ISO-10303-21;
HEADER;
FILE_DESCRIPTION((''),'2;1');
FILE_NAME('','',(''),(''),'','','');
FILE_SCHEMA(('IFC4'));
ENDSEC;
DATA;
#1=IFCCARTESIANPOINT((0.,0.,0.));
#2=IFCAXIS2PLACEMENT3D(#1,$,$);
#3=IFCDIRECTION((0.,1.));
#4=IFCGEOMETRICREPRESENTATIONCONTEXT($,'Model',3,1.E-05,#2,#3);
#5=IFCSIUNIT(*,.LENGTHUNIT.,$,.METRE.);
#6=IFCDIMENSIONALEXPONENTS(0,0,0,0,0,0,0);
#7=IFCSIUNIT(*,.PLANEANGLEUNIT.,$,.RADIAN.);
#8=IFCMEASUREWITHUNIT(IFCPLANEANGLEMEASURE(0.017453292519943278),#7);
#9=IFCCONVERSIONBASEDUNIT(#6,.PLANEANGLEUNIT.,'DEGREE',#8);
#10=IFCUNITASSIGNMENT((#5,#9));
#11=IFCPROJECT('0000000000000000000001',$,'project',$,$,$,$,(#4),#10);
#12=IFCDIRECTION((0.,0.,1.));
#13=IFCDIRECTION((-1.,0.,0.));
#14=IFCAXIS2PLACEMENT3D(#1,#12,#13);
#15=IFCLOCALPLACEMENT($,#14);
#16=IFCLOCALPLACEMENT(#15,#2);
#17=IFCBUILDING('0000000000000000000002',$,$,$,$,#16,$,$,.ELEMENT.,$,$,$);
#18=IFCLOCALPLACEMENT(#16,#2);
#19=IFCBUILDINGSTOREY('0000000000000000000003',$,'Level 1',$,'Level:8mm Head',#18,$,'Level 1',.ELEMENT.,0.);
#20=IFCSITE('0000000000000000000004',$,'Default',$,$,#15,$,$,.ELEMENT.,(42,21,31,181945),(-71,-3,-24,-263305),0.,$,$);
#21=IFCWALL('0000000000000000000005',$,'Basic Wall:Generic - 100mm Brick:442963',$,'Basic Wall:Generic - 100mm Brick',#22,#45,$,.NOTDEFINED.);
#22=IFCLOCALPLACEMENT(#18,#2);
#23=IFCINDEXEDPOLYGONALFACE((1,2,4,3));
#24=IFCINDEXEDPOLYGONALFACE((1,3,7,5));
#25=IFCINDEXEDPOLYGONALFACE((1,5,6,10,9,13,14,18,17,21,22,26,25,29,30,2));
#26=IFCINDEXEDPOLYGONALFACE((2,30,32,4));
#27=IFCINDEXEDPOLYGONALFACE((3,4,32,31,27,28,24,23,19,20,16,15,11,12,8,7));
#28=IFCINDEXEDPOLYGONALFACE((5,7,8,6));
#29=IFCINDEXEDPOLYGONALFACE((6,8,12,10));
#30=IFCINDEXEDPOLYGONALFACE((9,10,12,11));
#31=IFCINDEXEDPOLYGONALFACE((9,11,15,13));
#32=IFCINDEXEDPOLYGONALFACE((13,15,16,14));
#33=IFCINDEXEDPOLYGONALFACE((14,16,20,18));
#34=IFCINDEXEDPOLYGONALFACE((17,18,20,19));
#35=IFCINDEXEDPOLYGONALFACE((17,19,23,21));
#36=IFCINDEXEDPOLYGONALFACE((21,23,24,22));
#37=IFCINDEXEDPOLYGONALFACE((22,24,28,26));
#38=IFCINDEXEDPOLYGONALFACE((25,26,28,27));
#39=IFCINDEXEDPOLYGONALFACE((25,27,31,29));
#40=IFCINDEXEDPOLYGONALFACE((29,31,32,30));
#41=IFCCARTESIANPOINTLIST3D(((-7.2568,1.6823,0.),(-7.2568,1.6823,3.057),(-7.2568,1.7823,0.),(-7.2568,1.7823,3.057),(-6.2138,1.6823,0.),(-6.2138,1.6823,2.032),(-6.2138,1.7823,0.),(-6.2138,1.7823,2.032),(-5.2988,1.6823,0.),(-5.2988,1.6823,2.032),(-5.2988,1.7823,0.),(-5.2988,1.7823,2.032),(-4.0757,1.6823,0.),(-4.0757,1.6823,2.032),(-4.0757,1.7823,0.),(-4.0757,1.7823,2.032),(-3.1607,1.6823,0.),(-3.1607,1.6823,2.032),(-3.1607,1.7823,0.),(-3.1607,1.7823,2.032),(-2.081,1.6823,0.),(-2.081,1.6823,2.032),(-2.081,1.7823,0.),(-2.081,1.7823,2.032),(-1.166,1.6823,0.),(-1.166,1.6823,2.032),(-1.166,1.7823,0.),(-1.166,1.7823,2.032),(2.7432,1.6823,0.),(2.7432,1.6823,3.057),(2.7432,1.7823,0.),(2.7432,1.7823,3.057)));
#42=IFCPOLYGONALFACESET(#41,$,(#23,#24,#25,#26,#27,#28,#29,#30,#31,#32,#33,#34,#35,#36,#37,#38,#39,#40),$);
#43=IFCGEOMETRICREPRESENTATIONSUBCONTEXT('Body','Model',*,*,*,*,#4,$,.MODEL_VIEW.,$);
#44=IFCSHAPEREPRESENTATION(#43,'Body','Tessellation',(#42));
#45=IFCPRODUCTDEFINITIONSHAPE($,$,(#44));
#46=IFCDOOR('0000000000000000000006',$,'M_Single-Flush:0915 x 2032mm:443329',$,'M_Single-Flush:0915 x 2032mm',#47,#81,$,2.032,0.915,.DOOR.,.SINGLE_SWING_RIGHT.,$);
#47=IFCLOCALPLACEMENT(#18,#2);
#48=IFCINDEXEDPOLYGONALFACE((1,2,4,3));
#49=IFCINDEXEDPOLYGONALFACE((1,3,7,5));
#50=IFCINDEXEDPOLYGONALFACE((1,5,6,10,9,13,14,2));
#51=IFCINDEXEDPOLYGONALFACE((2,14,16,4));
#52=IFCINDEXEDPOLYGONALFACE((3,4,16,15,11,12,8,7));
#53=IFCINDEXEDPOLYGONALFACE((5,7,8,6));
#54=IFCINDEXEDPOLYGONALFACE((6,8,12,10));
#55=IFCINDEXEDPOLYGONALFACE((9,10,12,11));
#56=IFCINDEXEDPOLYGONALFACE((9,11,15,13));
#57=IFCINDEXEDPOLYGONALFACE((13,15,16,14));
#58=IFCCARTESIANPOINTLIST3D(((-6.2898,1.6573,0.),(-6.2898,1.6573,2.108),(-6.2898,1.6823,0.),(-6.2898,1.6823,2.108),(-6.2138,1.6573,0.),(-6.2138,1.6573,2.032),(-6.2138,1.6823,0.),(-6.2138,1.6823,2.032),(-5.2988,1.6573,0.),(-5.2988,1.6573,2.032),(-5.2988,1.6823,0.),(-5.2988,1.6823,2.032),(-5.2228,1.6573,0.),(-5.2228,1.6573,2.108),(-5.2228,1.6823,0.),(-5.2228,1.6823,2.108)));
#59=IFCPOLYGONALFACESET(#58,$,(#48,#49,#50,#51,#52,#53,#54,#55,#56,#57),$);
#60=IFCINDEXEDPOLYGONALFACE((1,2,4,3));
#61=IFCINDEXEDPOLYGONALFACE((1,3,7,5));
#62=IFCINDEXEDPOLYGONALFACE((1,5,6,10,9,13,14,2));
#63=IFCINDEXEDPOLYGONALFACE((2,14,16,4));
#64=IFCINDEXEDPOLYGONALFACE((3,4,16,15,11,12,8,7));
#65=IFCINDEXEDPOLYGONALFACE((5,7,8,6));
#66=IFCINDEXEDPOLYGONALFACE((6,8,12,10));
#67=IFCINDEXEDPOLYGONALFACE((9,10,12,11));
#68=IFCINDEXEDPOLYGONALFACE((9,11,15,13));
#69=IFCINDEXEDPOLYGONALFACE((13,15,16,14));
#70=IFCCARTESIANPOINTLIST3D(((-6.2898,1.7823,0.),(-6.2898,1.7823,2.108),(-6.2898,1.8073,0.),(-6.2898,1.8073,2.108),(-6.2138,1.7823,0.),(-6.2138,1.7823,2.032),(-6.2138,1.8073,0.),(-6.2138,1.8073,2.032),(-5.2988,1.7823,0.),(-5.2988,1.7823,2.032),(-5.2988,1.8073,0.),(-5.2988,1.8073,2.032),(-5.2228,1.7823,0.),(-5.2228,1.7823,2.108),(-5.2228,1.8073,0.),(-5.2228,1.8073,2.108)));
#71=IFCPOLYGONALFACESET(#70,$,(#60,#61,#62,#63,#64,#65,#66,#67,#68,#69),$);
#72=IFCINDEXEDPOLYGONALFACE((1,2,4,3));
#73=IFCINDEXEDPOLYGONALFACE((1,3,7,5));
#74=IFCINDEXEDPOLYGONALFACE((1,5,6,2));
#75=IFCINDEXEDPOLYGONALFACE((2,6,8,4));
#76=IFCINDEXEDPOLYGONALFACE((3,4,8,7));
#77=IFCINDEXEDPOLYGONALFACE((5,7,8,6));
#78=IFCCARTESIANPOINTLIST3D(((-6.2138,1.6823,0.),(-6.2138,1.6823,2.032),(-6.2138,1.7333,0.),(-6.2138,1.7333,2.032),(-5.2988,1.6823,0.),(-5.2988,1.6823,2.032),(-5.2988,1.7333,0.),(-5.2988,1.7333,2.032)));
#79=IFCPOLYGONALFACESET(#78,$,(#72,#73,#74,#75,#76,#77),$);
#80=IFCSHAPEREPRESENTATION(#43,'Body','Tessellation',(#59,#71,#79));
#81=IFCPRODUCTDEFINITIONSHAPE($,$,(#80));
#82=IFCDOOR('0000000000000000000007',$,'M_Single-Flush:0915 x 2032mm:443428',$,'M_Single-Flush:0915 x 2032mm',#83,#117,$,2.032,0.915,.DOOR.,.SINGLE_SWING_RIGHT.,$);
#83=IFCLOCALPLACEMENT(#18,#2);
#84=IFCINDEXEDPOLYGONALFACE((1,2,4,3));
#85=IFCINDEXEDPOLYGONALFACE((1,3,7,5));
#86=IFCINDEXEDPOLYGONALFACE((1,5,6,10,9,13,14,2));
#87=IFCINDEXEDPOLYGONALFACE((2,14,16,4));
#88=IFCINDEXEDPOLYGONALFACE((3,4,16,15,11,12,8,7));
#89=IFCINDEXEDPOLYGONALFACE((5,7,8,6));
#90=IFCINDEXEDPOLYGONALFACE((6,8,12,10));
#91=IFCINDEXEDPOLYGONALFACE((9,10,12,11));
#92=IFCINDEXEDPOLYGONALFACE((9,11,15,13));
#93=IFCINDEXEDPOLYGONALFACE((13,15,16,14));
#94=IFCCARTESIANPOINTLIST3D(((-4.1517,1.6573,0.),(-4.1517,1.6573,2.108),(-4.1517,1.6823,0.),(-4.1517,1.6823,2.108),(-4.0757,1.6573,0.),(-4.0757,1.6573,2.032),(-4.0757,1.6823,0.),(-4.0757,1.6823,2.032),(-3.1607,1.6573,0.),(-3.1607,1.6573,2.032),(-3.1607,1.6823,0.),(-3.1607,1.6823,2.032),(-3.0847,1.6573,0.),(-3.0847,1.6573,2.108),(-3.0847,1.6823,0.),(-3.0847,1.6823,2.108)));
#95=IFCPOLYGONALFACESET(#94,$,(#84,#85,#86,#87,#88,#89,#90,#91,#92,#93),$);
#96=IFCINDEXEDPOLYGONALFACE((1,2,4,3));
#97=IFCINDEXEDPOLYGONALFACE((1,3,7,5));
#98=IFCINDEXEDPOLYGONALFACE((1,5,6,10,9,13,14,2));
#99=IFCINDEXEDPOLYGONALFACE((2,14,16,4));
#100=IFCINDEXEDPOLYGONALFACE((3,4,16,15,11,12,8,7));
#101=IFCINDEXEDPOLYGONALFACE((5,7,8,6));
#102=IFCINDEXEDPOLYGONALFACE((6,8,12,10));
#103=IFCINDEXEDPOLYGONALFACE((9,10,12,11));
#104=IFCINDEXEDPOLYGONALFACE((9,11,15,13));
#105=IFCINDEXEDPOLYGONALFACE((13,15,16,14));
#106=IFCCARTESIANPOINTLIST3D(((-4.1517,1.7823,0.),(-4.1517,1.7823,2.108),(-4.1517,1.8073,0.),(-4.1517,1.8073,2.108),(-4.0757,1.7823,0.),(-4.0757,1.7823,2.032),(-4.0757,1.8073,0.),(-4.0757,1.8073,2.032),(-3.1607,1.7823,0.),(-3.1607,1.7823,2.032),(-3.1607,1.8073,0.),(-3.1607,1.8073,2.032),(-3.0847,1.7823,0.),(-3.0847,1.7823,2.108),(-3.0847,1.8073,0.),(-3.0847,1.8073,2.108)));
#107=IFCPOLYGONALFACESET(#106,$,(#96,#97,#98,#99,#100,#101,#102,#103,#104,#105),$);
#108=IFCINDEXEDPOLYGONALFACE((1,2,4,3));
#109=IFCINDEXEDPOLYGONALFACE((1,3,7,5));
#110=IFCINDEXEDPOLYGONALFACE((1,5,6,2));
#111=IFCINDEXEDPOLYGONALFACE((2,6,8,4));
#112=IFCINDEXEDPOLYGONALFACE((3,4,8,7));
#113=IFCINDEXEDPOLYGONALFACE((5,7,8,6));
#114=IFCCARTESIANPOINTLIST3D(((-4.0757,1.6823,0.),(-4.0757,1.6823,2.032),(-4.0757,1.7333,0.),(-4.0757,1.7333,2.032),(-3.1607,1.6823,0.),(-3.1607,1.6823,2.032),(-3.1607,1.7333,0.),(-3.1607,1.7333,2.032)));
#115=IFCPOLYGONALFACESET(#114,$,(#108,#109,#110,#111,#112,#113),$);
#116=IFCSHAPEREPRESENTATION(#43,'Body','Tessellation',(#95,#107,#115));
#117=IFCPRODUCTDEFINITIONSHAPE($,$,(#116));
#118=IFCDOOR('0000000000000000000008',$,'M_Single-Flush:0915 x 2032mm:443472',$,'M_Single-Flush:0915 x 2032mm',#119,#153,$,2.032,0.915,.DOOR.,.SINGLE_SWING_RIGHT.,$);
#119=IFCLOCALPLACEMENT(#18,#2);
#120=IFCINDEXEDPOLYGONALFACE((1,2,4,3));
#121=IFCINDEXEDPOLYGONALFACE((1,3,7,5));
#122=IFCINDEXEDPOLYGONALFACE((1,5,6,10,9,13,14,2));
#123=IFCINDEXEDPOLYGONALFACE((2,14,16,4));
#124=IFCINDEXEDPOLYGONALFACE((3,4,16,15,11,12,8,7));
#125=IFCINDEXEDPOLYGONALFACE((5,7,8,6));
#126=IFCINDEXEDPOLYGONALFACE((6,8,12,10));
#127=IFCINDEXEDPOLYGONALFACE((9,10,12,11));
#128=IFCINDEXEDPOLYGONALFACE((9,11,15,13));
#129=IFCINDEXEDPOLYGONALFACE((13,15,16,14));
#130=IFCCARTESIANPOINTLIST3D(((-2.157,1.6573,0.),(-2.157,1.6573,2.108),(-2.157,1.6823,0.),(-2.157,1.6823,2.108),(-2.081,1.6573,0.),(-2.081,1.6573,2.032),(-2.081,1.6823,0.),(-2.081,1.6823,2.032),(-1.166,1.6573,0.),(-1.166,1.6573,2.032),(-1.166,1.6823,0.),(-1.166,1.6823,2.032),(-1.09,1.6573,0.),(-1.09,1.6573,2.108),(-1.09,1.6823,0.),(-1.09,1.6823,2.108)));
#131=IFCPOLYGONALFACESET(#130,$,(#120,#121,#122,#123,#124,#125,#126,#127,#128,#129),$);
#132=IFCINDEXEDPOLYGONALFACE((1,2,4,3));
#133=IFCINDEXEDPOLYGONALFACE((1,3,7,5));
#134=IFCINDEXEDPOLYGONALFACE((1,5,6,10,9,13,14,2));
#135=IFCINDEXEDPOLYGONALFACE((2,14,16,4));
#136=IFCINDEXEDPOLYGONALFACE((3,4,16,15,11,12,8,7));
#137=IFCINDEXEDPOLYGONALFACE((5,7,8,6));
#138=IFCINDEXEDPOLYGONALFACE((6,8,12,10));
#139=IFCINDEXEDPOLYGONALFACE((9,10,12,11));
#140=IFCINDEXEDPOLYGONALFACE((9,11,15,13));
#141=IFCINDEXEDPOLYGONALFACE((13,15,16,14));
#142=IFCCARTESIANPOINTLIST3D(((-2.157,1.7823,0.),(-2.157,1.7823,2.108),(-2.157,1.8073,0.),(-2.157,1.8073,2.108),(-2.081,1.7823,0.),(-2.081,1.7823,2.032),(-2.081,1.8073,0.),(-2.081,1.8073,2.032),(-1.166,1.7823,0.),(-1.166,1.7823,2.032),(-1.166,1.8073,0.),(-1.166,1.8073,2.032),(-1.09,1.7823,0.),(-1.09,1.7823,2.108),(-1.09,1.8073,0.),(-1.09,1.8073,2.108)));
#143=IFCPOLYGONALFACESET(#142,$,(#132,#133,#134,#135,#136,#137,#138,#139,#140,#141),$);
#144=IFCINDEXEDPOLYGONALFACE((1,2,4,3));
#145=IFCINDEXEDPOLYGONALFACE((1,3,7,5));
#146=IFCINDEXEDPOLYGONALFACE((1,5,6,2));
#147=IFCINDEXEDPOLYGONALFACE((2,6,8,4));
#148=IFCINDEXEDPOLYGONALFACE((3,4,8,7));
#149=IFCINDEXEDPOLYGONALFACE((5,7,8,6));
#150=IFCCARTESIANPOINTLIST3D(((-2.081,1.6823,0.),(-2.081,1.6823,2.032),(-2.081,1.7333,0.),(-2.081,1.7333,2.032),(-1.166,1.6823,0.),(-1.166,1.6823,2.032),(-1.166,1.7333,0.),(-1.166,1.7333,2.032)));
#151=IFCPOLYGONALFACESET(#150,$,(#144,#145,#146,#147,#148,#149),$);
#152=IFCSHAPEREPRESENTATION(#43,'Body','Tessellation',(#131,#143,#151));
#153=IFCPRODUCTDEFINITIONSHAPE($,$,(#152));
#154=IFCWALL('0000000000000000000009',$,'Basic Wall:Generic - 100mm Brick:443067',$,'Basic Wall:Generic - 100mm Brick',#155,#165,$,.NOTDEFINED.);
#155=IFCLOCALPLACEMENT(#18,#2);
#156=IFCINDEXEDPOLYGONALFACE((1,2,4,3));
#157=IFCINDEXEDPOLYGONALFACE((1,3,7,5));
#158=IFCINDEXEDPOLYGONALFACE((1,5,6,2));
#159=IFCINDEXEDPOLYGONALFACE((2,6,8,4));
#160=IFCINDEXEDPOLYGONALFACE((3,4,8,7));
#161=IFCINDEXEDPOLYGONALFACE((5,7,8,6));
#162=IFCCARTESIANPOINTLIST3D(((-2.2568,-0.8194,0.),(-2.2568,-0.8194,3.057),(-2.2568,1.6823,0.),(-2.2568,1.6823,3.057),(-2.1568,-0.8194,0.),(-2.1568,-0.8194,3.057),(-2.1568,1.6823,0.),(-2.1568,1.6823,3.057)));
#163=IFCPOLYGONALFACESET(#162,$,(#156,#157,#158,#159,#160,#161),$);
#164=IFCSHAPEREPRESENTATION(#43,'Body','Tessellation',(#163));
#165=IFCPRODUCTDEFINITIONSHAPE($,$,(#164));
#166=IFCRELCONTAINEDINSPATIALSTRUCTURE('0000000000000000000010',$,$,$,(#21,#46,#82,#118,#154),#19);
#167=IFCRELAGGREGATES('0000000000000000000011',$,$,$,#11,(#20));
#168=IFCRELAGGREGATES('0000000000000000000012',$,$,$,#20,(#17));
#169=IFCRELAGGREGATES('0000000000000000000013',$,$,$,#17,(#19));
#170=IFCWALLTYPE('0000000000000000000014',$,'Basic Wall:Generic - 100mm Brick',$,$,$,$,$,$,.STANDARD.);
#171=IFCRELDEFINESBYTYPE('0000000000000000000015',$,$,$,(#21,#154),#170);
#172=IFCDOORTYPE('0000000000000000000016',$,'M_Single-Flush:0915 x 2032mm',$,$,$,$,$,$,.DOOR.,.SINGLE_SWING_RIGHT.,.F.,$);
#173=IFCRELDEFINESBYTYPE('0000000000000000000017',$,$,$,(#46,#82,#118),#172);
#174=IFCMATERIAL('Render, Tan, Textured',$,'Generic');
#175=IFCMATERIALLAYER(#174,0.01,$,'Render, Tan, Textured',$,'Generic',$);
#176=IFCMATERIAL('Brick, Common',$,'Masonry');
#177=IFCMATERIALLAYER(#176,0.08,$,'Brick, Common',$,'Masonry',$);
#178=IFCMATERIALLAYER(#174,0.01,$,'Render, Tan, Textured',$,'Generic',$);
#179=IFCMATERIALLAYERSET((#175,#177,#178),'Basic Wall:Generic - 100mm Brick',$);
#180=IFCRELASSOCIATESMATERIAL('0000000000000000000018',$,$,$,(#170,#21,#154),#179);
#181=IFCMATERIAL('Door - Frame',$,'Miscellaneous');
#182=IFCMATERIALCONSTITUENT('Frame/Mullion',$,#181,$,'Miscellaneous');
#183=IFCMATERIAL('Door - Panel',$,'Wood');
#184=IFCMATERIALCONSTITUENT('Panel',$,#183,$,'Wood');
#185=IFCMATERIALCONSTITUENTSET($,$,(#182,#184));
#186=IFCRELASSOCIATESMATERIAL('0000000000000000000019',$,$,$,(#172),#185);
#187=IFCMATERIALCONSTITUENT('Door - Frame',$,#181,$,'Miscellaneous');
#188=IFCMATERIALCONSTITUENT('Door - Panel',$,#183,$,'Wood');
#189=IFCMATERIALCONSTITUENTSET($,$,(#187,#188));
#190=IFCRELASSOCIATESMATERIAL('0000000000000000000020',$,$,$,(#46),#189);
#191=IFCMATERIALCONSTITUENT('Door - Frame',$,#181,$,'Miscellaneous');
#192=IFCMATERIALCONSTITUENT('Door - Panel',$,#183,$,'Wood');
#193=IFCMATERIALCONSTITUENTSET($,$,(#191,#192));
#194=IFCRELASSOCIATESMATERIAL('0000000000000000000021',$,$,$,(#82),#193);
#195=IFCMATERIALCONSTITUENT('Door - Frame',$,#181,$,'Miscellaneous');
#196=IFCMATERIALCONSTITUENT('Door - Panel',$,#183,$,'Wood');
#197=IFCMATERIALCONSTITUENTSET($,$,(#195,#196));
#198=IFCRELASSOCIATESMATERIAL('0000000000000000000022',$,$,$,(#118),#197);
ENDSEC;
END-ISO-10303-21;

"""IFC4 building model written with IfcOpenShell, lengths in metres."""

from ifc_helpers import new_model, entity, si_unit, converted_unit, direction, frame, frame_2d, origin, place, context, subcontext, project, spatial, polyline, rectangle, outline, extrude, source, transform, mapped, material, layer, layer_set, layer_usage, constituent, constituent_set, type_object, type_shapes, element, fill, save


model = new_model("IFC4")

# Units and contexts
model_context = context("Model", 3, precision=1e-05, world=origin(), true_north=direction((0.0, 1.0)))
body_context = subcontext(model_context, "Body", "Model", "MODEL_VIEW")
ifc_project = project(units=[si_unit("LENGTHUNIT", "METRE"), converted_unit("PLANEANGLEUNIT", "DEGREE", entity("IfcPlaneAngleMeasure", 0.017453292519943278), si_unit("PLANEANGLEUNIT", "RADIAN"), dimensions=[0, 0, 0, 0, 0, 0, 0])], contexts=[model_context])

# Site, building, storey
site_placement = place(None, frame((0.0, 0.0, 0.0), z_axis=(0.0, 0.0, 1.0), x_axis=(-1.0, 0.0, 0.0)))
site = spatial("IfcSite", under=ifc_project, at=site_placement, Name="Default", CompositionType="ELEMENT", RefLatitude=(42, 21, 31, 181945), RefLongitude=(-71, -3, -24, -263305), RefElevation=0.0)
building_placement = place(site_placement, origin())
building = spatial("IfcBuilding", under=site, at=building_placement, CompositionType="ELEMENT")
storey_placement = place(building_placement, origin())
storey = spatial("IfcBuildingStorey", under=building, at=storey_placement, Name="Level 1", ObjectType="Level:8mm Head", LongName="Level 1", CompositionType="ELEMENT", Elevation=0.0)

# Shared definitions
ifc_material_1 = material(Name="Brick, Common", Category="Masonry")

# Shared definitions
ifc_material_2 = material(Name="Render, Tan, Textured", Category="Generic")
ifc_layer_1 = layer(ifc_material_2, 0.01, Name="Render, Tan, Textured", Category="Generic")
ifc_layer_2 = layer(ifc_material_1, 0.08, Name="Brick, Common", Category="Masonry")
ifc_layer_3 = layer(ifc_material_2, 0.01, Name="Render, Tan, Textured", Category="Generic")
ifc_layer_set_1 = layer_set([ifc_layer_1, ifc_layer_2, ifc_layer_3], Name="Basic Wall:Generic - 100mm Brick")
ifc_layer_usage_1 = layer_usage(ifc_layer_set_1, "AXIS2", "NEGATIVE", 0.05)
wall_type_1 = type_object("IfcWallType", Name="Basic Wall:Generic - 100mm Brick", PredefinedType="STANDARD", material=ifc_layer_set_1)
ifc_material_3 = material(Name="Door - Frame", Category="Miscellaneous")
ifc_material_4 = material(Name="Door - Panel", Category="Wood")

# Wall, openings, doors
wall_1_placement = place(storey_placement, frame((-7.2568, 1.7323, 0.0)))
wall_1 = element("IfcWall", 1, at=wall_1_placement, inside=storey, type_object=wall_type_1, material=ifc_layer_usage_1, Name="Basic Wall:Generic - 100mm Brick:442963", ObjectType="Basic Wall:Generic - 100mm Brick", PredefinedType="NOTDEFINED", context=body_context, shape_type="SweptSolid", body=[
    extrude(rectangle(XDim=10.0, YDim=0.1, at=frame_2d((5.0, 0.0), x_axis=(1.0, 0.0))), origin(), (0.0, 0.0, 1.0), 3.057),
])
opening_1_placement = place(wall_1_placement, frame((1.958, 0.05, 0.0)))
opening_1 = element("IfcOpeningElement", 2, at=opening_1_placement, cuts=wall_1, PredefinedType="OPENING", context=body_context, shape_type="SweptSolid", body=[
    extrude(rectangle(XDim=0.915, YDim=2.032, at=frame_2d((1.016, 0.4575), x_axis=(0.0, 1.0))), frame((0.0, 0.0, 0.0), z_axis=(0.0, -1.0, 0.0), x_axis=(0.0, 0.0, 1.0)), (0.0, 0.0, 1.0), 0.1),
])
opening_2_placement = place(wall_1_placement, frame((4.0961, 0.05, 0.0)))
opening_2 = element("IfcOpeningElement", 3, at=opening_2_placement, cuts=wall_1, PredefinedType="OPENING", context=body_context, shape_type="SweptSolid", body=[
    extrude(rectangle(XDim=0.915, YDim=2.032, at=frame_2d((1.016, 0.4575), x_axis=(0.0, 1.0))), frame((0.0, 0.0, 0.0), z_axis=(0.0, -1.0, 0.0), x_axis=(0.0, 0.0, 1.0)), (0.0, 0.0, 1.0), 0.1),
])
opening_3_placement = place(wall_1_placement, frame((6.0908, 0.05, 0.0)))
opening_3 = element("IfcOpeningElement", 4, at=opening_3_placement, cuts=wall_1, PredefinedType="OPENING", context=body_context, shape_type="SweptSolid", body=[
    extrude(rectangle(XDim=0.915, YDim=2.032, at=frame_2d((1.016, 0.4575), x_axis=(0.0, 1.0))), frame((0.0, 0.0, 0.0), z_axis=(0.0, -1.0, 0.0), x_axis=(0.0, 0.0, 1.0)), (0.0, 0.0, 1.0), 0.1),
])
ifc_constituent_1 = constituent(ifc_material_3, Name="Door - Frame", Category="Miscellaneous")
ifc_constituent_2 = constituent(ifc_material_4, Name="Door - Panel", Category="Wood")
ifc_constituent_set_1 = constituent_set(constituents=[ifc_constituent_1, ifc_constituent_2])
ifc_constituent_3 = constituent(ifc_material_3, Name="Frame/Mullion", Category="Miscellaneous")
ifc_constituent_4 = constituent(ifc_material_4, Name="Panel", Category="Wood")
ifc_constituent_set_2 = constituent_set(constituents=[ifc_constituent_3, ifc_constituent_4])
door_type_1 = type_object("IfcDoorType", Name="M_Single-Flush:0915 x 2032mm", OperationType="SINGLE_SWING_RIGHT", ParameterTakesPrecedence=False, PredefinedType="DOOR", material=ifc_constituent_set_2)
shared_shape_1 = source(origin(), body_context, "Body", "SweptSolid", [
    extrude(outline(polyline([(-0.5335, -1.073), (0.5335, -1.073), (0.5335, 1.035), (0.4575, 1.035), (0.4575, -0.997), (-0.4575, -0.997), (-0.4575, 1.035), (-0.5335, 1.035), (-0.5335, -1.073)])), frame((0.4575, 0.1, 1.035), z_axis=(0.0, 1.0, 0.0), x_axis=(1.0, 0.0, 0.0)), (0.0, 0.0, 1.0), 0.025),
    extrude(outline(polyline([(-1.073, -0.5335), (1.035, -0.5335), (1.035, -0.4575), (-0.997, -0.4575), (-0.997, 0.4575), (1.035, 0.4575), (1.035, 0.5335), (-1.073, 0.5335), (-1.073, -0.5335)])), frame((0.4575, -0.025, 1.035), z_axis=(0.0, 1.0, 0.0), x_axis=(0.0, 0.0, -1.0)), (0.0, 0.0, 1.0), 0.025),
    extrude(rectangle(XDim=0.051, YDim=0.915, at=frame_2d((0.0, 0.0), x_axis=(1.0, 0.0))), frame((0.4575, 0.0745, 0.0), z_axis=(0.0, 0.0, 1.0), x_axis=(0.0, 1.0, 0.0)), (0.0, 0.0, 1.0), 2.032),
])
type_shapes(door_type_1, [shared_shape_1])
door_1_placement = place(opening_1_placement, frame((0.0, 0.0, 0.0), z_axis=(0.0, 0.0, 1.0), x_axis=(-1.0, 0.0, 0.0)))
door_1 = element("IfcDoor", 5, at=door_1_placement, inside=storey, type_object=door_type_1, material=ifc_constituent_set_1, Name="M_Single-Flush:0915 x 2032mm:443329", ObjectType="M_Single-Flush:0915 x 2032mm", OperationType="SINGLE_SWING_RIGHT", OverallHeight=2.032, OverallWidth=0.915, PredefinedType="DOOR", context=body_context, shape_type="MappedRepresentation", body=[
    mapped(shared_shape_1, transform((0.0, 0.0, 0.0), scale=1.0)),
])
fill(opening_1, door_1)
ifc_constituent_5 = constituent(ifc_material_3, Name="Door - Frame", Category="Miscellaneous")
ifc_constituent_6 = constituent(ifc_material_4, Name="Door - Panel", Category="Wood")
ifc_constituent_set_3 = constituent_set(constituents=[ifc_constituent_5, ifc_constituent_6])
door_2_placement = place(opening_2_placement, frame((0.0, 0.0, 0.0), z_axis=(0.0, 0.0, 1.0), x_axis=(-1.0, 0.0, 0.0)))
door_2 = element("IfcDoor", 6, at=door_2_placement, inside=storey, type_object=door_type_1, material=ifc_constituent_set_3, Name="M_Single-Flush:0915 x 2032mm:443428", ObjectType="M_Single-Flush:0915 x 2032mm", OperationType="SINGLE_SWING_RIGHT", OverallHeight=2.032, OverallWidth=0.915, PredefinedType="DOOR", context=body_context, shape_type="MappedRepresentation", body=[
    mapped(shared_shape_1, transform((0.0, 0.0, 0.0), scale=1.0)),
])
fill(opening_2, door_2)
ifc_constituent_7 = constituent(ifc_material_3, Name="Door - Frame", Category="Miscellaneous")
ifc_constituent_8 = constituent(ifc_material_4, Name="Door - Panel", Category="Wood")
ifc_constituent_set_4 = constituent_set(constituents=[ifc_constituent_7, ifc_constituent_8])
door_3_placement = place(opening_3_placement, frame((0.0, 0.0, 0.0), z_axis=(0.0, 0.0, 1.0), x_axis=(-1.0, 0.0, 0.0)))
door_3 = element("IfcDoor", 7, at=door_3_placement, inside=storey, type_object=door_type_1, material=ifc_constituent_set_4, Name="M_Single-Flush:0915 x 2032mm:443472", ObjectType="M_Single-Flush:0915 x 2032mm", OperationType="SINGLE_SWING_RIGHT", OverallHeight=2.032, OverallWidth=0.915, PredefinedType="DOOR", context=body_context, shape_type="MappedRepresentation", body=[
    mapped(shared_shape_1, transform((0.0, 0.0, 0.0), scale=1.0)),
])
fill(opening_3, door_3)

# Wall
wall_2_placement = place(storey_placement, frame((-2.2068, 1.6823, 0.0), z_axis=(0.0, 0.0, 1.0), x_axis=(0.0, -1.0, 0.0)))
element("IfcWall", 8, at=wall_2_placement, inside=storey, type_object=wall_type_1, material=ifc_layer_usage_1, Name="Basic Wall:Generic - 100mm Brick:443067", ObjectType="Basic Wall:Generic - 100mm Brick", PredefinedType="NOTDEFINED", context=body_context, shape_type="SweptSolid", body=[
    extrude(rectangle(XDim=2.5017, YDim=0.1, at=frame_2d((1.2508, 0.0), x_axis=(-1.0, 0.0))), origin(), (0.0, 0.0, 1.0), 3.057),
])

save(model, "model.ifc")
